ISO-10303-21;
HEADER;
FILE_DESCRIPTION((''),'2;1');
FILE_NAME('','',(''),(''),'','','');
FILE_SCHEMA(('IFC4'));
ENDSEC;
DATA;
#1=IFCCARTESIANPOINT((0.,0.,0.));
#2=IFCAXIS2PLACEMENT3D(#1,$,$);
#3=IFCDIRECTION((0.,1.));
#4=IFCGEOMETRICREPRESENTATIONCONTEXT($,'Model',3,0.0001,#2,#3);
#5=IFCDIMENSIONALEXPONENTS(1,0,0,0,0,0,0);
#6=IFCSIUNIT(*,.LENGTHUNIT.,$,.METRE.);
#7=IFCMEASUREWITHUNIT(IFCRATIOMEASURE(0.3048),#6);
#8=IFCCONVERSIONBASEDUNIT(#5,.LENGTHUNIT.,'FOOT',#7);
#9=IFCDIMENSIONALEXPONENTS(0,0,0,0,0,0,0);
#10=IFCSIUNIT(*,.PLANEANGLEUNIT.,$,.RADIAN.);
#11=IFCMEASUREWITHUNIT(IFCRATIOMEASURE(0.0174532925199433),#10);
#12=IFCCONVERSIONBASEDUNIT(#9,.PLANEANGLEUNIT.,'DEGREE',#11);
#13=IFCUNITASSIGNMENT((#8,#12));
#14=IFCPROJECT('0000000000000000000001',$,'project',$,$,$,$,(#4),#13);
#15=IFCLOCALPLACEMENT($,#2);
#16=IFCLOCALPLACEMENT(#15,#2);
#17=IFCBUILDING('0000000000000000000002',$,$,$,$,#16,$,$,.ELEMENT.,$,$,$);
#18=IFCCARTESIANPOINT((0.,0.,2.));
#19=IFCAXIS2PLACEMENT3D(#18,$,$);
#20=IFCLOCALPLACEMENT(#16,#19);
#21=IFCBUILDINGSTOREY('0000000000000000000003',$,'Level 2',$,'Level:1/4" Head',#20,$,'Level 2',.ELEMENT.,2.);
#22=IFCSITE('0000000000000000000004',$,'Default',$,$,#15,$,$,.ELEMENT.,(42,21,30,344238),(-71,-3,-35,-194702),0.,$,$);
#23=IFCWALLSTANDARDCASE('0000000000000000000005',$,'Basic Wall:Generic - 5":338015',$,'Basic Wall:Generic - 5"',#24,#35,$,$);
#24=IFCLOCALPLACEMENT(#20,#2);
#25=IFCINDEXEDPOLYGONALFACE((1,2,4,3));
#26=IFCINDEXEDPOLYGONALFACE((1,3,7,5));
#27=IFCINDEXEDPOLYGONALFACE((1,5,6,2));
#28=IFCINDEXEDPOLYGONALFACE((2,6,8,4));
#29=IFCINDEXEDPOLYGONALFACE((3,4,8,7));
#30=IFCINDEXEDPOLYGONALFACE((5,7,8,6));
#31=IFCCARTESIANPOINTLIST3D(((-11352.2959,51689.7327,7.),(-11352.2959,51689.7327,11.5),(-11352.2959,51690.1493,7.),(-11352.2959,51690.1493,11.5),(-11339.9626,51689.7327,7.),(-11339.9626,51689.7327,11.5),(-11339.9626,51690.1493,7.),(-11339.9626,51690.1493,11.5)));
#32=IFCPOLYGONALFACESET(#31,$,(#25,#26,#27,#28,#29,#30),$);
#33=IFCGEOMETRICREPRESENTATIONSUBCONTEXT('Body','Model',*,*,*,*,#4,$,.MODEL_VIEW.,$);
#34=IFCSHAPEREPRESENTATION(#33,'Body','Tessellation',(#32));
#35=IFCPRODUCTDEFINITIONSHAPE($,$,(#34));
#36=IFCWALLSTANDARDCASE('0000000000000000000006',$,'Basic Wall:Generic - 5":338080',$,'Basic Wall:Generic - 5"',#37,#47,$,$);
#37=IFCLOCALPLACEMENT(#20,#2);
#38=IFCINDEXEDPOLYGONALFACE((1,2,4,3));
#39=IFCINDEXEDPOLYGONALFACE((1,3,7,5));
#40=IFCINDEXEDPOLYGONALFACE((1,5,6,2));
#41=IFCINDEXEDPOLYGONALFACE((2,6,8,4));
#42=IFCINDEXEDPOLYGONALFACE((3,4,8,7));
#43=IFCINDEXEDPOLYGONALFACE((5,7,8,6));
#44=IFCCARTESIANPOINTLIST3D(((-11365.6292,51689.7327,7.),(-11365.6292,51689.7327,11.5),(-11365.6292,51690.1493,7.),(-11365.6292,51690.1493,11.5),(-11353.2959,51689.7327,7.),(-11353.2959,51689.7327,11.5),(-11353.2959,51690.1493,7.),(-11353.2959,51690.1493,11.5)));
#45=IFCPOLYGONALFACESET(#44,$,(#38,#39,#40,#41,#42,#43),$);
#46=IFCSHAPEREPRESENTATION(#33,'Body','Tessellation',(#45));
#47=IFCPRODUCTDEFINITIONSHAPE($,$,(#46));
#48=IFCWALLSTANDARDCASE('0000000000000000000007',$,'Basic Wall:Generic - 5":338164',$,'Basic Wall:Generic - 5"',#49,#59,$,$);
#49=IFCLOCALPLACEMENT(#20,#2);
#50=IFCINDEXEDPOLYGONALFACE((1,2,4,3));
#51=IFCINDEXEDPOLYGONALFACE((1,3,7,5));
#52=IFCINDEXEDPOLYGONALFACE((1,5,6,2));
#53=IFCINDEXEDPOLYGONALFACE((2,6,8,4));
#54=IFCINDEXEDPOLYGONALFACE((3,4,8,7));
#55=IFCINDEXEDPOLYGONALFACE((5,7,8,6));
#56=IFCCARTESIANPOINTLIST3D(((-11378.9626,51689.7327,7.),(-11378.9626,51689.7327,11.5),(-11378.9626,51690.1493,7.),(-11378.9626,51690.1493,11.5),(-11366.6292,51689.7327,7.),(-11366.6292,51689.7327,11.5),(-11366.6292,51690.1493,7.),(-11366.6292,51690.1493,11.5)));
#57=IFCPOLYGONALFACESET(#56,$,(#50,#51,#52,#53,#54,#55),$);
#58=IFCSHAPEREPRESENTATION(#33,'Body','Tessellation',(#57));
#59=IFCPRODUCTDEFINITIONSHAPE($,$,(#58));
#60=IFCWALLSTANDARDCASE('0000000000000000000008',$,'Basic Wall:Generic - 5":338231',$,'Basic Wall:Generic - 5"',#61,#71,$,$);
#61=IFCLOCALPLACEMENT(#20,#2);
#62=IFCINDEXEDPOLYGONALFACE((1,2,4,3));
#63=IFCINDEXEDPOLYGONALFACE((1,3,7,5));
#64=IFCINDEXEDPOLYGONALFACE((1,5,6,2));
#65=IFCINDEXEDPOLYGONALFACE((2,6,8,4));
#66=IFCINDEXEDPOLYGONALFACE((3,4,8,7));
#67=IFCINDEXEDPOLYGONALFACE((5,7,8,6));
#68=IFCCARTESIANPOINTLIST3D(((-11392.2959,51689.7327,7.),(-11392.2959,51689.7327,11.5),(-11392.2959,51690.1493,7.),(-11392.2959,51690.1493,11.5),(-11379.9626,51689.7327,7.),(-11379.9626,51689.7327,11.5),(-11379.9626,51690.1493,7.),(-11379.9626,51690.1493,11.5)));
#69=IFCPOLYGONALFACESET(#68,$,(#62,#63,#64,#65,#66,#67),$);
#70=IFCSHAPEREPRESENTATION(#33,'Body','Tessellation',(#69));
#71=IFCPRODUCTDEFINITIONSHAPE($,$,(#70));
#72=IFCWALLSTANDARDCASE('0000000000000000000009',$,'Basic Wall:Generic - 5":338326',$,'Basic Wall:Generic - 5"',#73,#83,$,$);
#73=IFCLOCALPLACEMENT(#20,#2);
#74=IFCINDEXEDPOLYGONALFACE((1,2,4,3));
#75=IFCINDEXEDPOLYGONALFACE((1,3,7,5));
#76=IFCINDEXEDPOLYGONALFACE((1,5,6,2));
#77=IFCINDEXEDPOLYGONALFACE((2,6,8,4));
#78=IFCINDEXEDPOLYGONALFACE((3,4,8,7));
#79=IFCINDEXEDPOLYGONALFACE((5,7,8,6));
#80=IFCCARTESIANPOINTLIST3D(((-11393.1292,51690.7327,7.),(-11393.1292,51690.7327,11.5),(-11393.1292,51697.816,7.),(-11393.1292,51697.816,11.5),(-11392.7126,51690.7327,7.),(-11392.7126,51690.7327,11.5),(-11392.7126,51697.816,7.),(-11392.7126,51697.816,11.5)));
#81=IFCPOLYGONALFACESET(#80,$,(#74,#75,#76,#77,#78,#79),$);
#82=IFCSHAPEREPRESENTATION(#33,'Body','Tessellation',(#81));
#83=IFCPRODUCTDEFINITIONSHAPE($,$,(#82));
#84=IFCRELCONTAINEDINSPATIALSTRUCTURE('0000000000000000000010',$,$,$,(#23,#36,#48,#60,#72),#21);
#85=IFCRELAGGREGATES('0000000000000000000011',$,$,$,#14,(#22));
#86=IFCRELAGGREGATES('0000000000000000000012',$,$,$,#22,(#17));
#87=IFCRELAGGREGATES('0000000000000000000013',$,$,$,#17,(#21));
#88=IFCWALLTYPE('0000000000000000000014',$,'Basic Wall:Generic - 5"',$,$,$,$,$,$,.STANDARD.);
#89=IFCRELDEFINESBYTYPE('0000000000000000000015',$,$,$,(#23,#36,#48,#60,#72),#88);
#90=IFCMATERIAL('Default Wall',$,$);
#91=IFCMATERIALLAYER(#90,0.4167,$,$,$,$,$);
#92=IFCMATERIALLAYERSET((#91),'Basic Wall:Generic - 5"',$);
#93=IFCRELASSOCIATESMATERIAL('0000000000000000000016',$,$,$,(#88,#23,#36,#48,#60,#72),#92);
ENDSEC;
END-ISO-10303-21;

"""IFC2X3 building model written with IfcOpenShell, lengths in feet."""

from ifc_helpers import new_model, entity, si_unit, converted_unit, direction, frame, frame_2d, origin, place, context, subcontext, project, spatial, rectangle, extrude, material, layer, layer_set, layer_usage, type_object, element, save


model = new_model("IFC2X3")

# Units and contexts
model_context = context("Model", 3, precision=0.0001, world=origin(), true_north=direction((0.0, 1.0)))
body_context = subcontext(model_context, "Body", "Model", "MODEL_VIEW")
ifc_project = project(units=[converted_unit("LENGTHUNIT", "FOOT", entity("IfcRatioMeasure", 0.3048), si_unit("LENGTHUNIT", "METRE"), dimensions=[1, 0, 0, 0, 0, 0, 0]), converted_unit("PLANEANGLEUNIT", "DEGREE", entity("IfcRatioMeasure", 0.0174532925199433), si_unit("PLANEANGLEUNIT", "RADIAN"), dimensions=[0, 0, 0, 0, 0, 0, 0])], contexts=[model_context])

# Site, building, storey
site_placement = place(None, origin())
site = spatial("IfcSite", under=ifc_project, at=site_placement, Name="Default", CompositionType="ELEMENT", RefLatitude=(42, 21, 30, 344238), RefLongitude=(-71, -3, -35, -194702), RefElevation=0.0)
building_placement = place(site_placement, origin())
building = spatial("IfcBuilding", under=site, at=building_placement, CompositionType="ELEMENT")
storey_placement = place(building_placement, frame((0.0, 0.0, 2.0)))
storey = spatial("IfcBuildingStorey", under=building, at=storey_placement, Name="Level 2", ObjectType="Level:1/4\" Head", LongName="Level 2", CompositionType="ELEMENT", Elevation=2.0)

# Shared definitions
ifc_material_1 = material(Name="Default Wall")
ifc_layer_1 = layer(ifc_material_1, 0.4167)
ifc_layer_set_1 = layer_set([ifc_layer_1], Name="Basic Wall:Generic - 5\"")
wall_type = type_object("IfcWallType", Name="Basic Wall:Generic - 5\"", PredefinedType="STANDARD", material=ifc_layer_set_1)

# Walls
ifc_layer_usage_1 = layer_usage(ifc_layer_set_1, "AXIS2", "NEGATIVE", 0.2083)
wall_1_placement = place(storey_placement, frame((-11339.9626, 51689.941, 7.0), z_axis=(0.0, 0.0, 1.0), x_axis=(-1.0, 0.0, 0.0)))
element("IfcWallStandardCase", 1, at=wall_1_placement, inside=storey, type_object=wall_type, material=ifc_layer_usage_1, Name="Basic Wall:Generic - 5\":338015", ObjectType="Basic Wall:Generic - 5\"", context=body_context, shape_type="SweptSolid", body=[
    extrude(rectangle(XDim=12.3333, YDim=0.4167, at=frame_2d((6.1667, 0.0), x_axis=(-1.0, 0.0))), origin(), (0.0, 0.0, 1.0), 4.5),
])
ifc_layer_usage_2 = layer_usage(ifc_layer_set_1, "AXIS2", "NEGATIVE", 0.2083)
wall_2_placement = place(storey_placement, frame((-11353.2959, 51689.941, 7.0), z_axis=(0.0, 0.0, 1.0), x_axis=(-1.0, 0.0, 0.0)))
element("IfcWallStandardCase", 2, at=wall_2_placement, inside=storey, type_object=wall_type, material=ifc_layer_usage_2, Name="Basic Wall:Generic - 5\":338080", ObjectType="Basic Wall:Generic - 5\"", context=body_context, shape_type="SweptSolid", body=[
    extrude(rectangle(XDim=12.3333, YDim=0.4167, at=frame_2d((6.1667, 0.0), x_axis=(-1.0, 0.0))), origin(), (0.0, 0.0, 1.0), 4.5),
])
ifc_layer_usage_3 = layer_usage(ifc_layer_set_1, "AXIS2", "NEGATIVE", 0.2083)
wall_3_placement = place(storey_placement, frame((-11366.6292, 51689.941, 7.0), z_axis=(0.0, 0.0, 1.0), x_axis=(-1.0, 0.0, 0.0)))
element("IfcWallStandardCase", 3, at=wall_3_placement, inside=storey, type_object=wall_type, material=ifc_layer_usage_3, Name="Basic Wall:Generic - 5\":338164", ObjectType="Basic Wall:Generic - 5\"", context=body_context, shape_type="SweptSolid", body=[
    extrude(rectangle(XDim=12.3333, YDim=0.4167, at=frame_2d((6.1667, 0.0), x_axis=(-1.0, 0.0))), origin(), (0.0, 0.0, 1.0), 4.5),
])
ifc_layer_usage_4 = layer_usage(ifc_layer_set_1, "AXIS2", "NEGATIVE", 0.2083)
wall_4_placement = place(storey_placement, frame((-11379.9626, 51689.941, 7.0), z_axis=(0.0, 0.0, 1.0), x_axis=(-1.0, 0.0, 0.0)))
element("IfcWallStandardCase", 4, at=wall_4_placement, inside=storey, type_object=wall_type, material=ifc_layer_usage_4, Name="Basic Wall:Generic - 5\":338231", ObjectType="Basic Wall:Generic - 5\"", context=body_context, shape_type="SweptSolid", body=[
    extrude(rectangle(XDim=12.3333, YDim=0.4167, at=frame_2d((6.1667, 0.0), x_axis=(-1.0, 0.0))), origin(), (0.0, 0.0, 1.0), 4.5),
])
ifc_layer_usage_5 = layer_usage(ifc_layer_set_1, "AXIS2", "POSITIVE", -0.2083)
wall_5_placement = place(storey_placement, frame((-11392.9209, 51697.816, 7.0), z_axis=(0.0, 0.0, 1.0), x_axis=(0.0, -1.0, 0.0)))
element("IfcWallStandardCase", 5, at=wall_5_placement, inside=storey, type_object=wall_type, material=ifc_layer_usage_5, Name="Basic Wall:Generic - 5\":338326", ObjectType="Basic Wall:Generic - 5\"", context=body_context, shape_type="SweptSolid", body=[
    extrude(rectangle(XDim=7.0833, YDim=0.4167, at=frame_2d((3.5417, 0.0), x_axis=(-1.0, 0.0))), origin(), (0.0, 0.0, 1.0), 4.5),
])

save(model, "model.ifc")
